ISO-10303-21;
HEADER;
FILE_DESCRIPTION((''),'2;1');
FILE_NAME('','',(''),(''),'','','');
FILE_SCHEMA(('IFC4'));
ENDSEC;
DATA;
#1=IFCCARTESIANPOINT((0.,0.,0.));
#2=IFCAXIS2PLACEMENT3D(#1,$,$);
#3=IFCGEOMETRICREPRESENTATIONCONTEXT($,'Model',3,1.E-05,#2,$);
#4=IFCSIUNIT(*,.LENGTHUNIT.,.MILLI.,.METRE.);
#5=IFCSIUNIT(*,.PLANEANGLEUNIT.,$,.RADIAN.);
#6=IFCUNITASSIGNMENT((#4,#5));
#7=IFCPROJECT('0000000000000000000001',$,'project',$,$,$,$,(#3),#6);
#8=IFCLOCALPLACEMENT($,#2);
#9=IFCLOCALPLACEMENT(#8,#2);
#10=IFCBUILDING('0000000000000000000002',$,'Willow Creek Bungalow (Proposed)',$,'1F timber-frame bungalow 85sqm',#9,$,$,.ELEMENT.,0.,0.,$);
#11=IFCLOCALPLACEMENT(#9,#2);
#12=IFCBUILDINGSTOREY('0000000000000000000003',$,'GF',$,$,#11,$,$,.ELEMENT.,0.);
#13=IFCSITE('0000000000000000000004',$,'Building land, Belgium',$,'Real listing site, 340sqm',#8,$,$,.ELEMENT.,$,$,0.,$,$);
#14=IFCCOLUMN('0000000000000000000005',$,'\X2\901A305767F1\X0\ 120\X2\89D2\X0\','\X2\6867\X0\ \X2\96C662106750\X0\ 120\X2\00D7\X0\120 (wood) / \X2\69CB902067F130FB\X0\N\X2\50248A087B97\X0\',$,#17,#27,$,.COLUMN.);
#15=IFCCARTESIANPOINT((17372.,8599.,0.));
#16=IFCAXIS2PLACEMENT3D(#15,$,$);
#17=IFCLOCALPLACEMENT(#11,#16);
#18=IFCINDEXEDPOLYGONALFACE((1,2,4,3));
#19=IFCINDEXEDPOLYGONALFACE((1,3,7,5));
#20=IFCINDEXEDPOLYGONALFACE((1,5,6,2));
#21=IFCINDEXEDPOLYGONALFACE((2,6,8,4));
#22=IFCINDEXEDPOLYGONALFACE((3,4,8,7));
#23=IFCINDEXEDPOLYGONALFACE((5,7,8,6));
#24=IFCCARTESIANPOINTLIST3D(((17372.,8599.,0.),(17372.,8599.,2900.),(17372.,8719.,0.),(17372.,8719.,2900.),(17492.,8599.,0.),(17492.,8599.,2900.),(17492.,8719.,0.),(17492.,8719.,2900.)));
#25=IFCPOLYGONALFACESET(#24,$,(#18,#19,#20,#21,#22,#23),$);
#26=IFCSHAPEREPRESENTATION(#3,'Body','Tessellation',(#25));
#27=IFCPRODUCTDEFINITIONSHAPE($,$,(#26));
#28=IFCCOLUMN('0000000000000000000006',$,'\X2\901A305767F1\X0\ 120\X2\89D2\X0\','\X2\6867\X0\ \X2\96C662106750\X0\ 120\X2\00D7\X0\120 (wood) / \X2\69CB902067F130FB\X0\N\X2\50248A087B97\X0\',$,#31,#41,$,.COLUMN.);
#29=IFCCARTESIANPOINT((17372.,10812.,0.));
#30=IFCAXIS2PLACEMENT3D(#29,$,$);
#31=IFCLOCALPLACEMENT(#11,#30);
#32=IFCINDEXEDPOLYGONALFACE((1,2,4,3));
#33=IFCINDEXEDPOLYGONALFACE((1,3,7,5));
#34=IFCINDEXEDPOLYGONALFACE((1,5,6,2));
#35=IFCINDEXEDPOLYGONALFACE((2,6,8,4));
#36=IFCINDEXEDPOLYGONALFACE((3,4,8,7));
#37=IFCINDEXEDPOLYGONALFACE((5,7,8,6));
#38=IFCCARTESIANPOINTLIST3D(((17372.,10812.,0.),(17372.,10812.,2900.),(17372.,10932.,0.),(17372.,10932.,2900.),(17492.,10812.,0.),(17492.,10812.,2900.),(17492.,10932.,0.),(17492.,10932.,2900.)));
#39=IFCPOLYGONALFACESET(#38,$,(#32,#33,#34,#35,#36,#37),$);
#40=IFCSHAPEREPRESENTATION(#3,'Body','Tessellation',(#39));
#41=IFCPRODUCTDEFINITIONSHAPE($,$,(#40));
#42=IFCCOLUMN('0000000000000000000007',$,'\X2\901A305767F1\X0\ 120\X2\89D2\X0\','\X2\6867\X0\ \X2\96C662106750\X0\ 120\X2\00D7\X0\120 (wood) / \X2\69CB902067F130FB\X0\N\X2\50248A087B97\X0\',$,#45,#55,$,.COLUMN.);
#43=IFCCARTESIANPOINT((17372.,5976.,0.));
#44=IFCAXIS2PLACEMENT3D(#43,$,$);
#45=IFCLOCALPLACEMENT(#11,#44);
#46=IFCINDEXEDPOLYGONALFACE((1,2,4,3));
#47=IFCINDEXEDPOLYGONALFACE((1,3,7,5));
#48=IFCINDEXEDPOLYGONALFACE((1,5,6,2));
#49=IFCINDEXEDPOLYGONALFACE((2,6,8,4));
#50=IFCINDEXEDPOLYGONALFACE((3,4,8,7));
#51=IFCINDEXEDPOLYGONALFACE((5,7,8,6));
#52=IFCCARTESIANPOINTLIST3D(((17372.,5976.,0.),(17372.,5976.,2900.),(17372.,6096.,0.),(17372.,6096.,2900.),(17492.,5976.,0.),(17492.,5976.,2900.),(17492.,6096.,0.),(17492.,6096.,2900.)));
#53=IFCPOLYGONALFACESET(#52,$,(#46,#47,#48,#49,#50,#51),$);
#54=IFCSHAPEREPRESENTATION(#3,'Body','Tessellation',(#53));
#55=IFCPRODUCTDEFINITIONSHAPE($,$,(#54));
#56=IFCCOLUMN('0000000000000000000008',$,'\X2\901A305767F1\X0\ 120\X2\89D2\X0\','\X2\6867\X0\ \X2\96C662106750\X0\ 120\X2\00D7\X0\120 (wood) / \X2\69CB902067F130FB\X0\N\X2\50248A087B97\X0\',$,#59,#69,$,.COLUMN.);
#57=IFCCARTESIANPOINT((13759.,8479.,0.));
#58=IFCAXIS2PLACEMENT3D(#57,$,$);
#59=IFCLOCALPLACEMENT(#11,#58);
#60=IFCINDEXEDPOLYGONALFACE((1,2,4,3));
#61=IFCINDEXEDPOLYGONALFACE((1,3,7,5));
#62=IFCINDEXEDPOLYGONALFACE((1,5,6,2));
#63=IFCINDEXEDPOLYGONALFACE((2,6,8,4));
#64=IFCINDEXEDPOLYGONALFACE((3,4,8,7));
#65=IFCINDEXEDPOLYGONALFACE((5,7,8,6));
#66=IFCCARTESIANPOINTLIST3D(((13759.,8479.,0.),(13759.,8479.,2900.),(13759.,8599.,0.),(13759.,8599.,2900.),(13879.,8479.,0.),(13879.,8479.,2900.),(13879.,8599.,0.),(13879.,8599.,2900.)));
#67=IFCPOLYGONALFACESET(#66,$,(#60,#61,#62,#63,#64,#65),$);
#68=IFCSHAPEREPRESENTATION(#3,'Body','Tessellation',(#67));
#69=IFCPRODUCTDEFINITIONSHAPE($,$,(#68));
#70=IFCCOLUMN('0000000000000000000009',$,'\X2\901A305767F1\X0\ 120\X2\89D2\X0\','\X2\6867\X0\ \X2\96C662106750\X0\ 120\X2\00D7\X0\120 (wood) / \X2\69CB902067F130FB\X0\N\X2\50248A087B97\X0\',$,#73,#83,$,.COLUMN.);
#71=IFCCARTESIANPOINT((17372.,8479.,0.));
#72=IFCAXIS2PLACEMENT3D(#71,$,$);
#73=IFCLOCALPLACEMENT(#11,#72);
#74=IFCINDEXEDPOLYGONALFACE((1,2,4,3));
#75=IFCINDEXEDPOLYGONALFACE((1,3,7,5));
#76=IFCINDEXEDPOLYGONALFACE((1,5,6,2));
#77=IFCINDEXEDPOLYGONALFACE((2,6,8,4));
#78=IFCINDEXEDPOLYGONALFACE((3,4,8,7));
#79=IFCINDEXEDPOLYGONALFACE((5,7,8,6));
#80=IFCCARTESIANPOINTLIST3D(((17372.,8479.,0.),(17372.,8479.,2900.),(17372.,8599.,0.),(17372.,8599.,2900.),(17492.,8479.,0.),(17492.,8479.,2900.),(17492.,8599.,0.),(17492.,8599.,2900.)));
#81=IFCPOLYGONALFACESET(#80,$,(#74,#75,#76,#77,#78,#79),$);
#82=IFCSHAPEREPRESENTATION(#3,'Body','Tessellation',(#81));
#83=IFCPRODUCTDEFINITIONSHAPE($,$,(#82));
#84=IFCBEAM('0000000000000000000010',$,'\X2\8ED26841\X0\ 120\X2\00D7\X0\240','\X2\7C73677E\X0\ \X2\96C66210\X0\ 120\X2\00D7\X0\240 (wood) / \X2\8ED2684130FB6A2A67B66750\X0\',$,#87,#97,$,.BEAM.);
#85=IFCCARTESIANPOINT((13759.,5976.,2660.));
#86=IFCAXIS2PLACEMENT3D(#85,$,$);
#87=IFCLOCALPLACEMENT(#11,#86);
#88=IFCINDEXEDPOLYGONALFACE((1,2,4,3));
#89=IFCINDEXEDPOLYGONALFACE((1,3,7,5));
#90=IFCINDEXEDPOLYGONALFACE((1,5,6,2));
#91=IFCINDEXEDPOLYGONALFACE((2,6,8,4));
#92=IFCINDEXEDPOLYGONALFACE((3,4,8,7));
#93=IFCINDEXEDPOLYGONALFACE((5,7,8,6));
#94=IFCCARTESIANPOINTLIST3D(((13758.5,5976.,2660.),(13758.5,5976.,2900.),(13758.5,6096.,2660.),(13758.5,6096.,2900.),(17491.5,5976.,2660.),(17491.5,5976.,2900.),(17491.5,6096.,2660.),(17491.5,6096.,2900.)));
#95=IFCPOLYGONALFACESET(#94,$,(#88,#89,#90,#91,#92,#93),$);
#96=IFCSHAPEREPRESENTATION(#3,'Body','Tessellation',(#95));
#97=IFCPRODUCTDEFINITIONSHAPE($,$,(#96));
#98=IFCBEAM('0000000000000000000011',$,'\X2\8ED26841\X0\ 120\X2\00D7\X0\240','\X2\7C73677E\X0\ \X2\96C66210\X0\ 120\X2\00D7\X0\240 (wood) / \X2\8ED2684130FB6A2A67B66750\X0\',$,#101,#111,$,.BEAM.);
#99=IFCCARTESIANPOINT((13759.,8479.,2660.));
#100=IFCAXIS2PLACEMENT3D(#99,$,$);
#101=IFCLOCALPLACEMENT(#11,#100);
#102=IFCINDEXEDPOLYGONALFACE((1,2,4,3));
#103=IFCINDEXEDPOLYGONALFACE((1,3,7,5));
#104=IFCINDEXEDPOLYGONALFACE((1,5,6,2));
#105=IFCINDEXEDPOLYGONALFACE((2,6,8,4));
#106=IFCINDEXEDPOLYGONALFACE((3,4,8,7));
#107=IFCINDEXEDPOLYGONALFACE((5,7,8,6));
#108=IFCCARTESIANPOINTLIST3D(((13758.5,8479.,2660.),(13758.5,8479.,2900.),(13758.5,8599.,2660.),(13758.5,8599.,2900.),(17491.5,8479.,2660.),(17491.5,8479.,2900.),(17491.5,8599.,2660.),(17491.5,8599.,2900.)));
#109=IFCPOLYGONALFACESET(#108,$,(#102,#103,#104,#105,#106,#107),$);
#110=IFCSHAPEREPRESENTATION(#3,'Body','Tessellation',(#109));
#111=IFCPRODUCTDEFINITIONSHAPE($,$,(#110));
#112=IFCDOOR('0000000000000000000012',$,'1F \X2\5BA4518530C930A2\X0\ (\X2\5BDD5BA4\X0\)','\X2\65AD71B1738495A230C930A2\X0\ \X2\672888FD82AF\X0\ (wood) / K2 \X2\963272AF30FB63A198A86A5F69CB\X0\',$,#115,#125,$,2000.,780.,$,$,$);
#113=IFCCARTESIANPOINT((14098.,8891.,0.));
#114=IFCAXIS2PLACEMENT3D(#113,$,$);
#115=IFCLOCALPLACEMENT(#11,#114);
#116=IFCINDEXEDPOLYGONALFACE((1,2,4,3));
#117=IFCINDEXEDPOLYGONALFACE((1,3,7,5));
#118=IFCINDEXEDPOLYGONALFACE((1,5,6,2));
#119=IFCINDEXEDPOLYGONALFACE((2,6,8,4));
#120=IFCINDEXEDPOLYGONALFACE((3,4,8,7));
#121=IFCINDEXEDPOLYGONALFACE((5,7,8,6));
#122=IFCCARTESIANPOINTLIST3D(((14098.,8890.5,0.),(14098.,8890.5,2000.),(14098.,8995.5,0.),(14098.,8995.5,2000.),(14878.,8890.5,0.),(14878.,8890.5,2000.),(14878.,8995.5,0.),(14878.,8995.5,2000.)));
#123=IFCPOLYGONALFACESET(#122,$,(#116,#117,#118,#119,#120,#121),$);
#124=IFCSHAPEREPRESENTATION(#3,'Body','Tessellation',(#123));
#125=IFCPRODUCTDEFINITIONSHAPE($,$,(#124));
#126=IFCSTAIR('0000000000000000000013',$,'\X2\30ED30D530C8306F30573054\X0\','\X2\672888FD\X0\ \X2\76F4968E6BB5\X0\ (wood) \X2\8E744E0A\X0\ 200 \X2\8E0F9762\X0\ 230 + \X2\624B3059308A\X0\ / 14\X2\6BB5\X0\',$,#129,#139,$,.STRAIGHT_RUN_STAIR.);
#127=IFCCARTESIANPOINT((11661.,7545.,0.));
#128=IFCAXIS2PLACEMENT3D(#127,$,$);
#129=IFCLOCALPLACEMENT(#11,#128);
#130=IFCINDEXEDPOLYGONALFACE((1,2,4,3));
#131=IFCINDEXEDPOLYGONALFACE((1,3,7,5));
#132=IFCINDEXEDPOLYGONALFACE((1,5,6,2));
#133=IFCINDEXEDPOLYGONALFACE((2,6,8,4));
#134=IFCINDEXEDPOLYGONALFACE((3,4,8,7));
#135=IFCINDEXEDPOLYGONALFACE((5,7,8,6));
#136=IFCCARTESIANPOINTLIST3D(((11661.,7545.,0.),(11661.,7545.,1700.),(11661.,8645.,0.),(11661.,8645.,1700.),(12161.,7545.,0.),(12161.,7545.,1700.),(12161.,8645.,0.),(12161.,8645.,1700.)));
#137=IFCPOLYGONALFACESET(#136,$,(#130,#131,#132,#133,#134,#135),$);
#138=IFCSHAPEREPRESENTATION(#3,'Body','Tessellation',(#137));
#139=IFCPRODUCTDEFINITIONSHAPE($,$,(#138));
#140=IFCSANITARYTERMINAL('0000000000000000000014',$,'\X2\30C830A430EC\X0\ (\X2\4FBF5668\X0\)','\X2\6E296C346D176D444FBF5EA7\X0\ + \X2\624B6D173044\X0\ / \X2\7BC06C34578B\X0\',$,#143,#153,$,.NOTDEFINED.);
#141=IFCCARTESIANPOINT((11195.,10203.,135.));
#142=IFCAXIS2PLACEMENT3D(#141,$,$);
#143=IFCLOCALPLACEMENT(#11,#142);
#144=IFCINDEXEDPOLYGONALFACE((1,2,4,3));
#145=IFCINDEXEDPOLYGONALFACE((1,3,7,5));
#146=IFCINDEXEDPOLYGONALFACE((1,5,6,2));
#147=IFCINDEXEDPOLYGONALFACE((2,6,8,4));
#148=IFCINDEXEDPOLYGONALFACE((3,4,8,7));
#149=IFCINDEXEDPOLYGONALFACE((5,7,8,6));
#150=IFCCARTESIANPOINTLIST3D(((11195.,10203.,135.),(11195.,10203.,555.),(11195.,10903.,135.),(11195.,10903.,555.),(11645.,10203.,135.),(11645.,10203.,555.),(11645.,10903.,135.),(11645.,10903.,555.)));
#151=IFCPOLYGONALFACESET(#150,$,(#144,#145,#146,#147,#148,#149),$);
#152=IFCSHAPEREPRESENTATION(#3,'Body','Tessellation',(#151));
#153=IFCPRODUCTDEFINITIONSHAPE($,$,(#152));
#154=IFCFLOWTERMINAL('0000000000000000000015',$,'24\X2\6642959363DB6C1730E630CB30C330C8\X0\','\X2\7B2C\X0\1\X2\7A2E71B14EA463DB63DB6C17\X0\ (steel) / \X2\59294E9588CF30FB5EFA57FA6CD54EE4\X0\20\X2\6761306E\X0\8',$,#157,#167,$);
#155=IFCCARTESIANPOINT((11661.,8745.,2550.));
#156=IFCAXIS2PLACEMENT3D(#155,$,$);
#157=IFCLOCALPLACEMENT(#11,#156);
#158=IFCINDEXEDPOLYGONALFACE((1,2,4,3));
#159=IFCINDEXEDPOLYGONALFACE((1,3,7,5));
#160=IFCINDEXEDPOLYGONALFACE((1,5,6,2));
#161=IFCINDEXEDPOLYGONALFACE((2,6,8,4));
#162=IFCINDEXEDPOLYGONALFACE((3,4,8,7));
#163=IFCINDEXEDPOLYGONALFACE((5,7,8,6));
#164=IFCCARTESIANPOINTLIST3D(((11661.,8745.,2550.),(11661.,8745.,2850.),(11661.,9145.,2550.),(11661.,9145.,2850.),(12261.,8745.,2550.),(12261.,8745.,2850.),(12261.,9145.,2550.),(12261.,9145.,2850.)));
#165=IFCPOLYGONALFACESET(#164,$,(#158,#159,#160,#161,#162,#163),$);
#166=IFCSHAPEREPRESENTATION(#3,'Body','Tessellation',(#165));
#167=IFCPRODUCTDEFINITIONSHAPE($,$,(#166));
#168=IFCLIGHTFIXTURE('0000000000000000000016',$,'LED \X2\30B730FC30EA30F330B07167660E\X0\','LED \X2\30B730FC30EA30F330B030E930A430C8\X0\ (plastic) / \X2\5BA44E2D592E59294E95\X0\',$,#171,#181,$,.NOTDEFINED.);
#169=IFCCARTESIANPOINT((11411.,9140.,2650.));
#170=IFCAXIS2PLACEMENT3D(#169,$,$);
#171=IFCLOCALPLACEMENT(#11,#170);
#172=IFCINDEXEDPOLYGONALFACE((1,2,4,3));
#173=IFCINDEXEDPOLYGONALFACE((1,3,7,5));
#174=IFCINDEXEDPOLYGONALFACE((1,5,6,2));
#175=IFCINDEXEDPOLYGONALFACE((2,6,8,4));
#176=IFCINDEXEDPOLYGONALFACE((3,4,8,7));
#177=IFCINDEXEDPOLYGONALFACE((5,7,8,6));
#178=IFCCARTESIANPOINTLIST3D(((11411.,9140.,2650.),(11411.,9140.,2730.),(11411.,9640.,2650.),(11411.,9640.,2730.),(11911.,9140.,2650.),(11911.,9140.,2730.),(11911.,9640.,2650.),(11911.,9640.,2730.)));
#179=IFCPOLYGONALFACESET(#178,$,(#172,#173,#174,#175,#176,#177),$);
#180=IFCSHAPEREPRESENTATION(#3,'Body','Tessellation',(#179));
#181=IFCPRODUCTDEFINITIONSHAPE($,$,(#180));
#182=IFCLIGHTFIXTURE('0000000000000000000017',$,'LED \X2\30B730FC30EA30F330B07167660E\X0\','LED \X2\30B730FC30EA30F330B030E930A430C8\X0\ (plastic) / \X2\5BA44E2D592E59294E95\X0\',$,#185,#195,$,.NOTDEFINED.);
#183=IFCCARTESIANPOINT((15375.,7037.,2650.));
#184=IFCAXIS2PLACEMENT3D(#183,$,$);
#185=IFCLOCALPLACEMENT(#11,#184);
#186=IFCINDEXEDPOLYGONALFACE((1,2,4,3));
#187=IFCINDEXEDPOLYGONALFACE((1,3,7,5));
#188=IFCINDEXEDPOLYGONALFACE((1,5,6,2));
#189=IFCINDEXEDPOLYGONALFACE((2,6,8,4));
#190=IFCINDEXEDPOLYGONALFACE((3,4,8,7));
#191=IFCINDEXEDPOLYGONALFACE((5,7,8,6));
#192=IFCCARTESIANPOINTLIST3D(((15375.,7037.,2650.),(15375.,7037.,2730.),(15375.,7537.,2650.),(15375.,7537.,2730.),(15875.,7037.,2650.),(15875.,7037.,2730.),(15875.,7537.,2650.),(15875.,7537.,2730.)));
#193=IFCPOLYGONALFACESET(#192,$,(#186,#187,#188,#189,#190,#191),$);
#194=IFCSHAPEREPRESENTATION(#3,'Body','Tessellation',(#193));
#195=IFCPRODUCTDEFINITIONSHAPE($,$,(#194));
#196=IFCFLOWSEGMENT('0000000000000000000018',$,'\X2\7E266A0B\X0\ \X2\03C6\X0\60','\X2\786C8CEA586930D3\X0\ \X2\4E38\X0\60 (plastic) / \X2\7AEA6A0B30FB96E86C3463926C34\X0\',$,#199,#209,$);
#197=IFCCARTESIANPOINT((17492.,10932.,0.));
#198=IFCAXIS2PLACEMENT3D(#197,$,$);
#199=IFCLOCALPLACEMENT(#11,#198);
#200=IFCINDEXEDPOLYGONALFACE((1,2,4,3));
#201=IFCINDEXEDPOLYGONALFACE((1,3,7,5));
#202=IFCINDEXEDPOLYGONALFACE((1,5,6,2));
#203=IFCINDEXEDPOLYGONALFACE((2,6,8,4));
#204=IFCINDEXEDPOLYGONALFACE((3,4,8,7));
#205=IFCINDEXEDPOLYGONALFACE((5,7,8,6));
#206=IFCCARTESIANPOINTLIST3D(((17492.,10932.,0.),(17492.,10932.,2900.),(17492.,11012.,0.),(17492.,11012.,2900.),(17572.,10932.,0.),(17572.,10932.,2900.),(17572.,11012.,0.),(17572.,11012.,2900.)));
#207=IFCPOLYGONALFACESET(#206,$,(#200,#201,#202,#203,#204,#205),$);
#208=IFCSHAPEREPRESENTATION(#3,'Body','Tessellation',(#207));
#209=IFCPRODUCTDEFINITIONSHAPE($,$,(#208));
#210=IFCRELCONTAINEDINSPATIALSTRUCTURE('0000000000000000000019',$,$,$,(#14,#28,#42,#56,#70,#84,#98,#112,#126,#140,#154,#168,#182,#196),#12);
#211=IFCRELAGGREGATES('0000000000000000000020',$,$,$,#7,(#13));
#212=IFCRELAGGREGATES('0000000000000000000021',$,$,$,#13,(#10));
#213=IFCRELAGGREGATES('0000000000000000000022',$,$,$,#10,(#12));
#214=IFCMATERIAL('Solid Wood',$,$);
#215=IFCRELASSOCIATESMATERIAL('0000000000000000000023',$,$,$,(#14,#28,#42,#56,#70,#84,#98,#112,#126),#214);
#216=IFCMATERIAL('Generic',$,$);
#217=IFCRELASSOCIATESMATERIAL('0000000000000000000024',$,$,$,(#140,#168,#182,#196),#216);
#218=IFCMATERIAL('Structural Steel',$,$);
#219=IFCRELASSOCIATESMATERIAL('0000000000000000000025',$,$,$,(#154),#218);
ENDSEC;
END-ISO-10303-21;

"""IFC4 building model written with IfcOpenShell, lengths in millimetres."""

from ifc_helpers import new_model, si_unit, frame, frame_2d, origin, place, context, project, spatial, rectangle, extrude, material, element, save


model = new_model("IFC4")

# Units and contexts
model_context = context("Model", 3, precision=1e-05, world=origin())
ifc_project = project(units=[si_unit("LENGTHUNIT", "METRE", prefix="MILLI"), si_unit("PLANEANGLEUNIT", "RADIAN")], contexts=[model_context])

# Site, building, storey
site_placement = place(None, origin())
site = spatial("IfcSite", under=ifc_project, at=site_placement, Name="Building land, Belgium", ObjectType="Real listing site, 340sqm", CompositionType="ELEMENT", RefElevation=0.0)
building_placement = place(site_placement, origin())
building = spatial("IfcBuilding", under=site, at=building_placement, Name="Willow Creek Bungalow (Proposed)", ObjectType="1F timber-frame bungalow 85sqm", CompositionType="ELEMENT", ElevationOfRefHeight=0.0, ElevationOfTerrain=0.0)
storey_placement = place(building_placement, origin())
storey = spatial("IfcBuildingStorey", under=building, at=storey_placement, Name="GF", CompositionType="ELEMENT", Elevation=0.0)

# Columns
ifc_material_1 = material(Name="Solid Wood")
column_1_placement = place(storey_placement, frame((17372.0, 8599.0, 0.0)))
element("IfcColumn", 1, at=column_1_placement, inside=storey, material=ifc_material_1, Name="通し柱 120角", Description="桧 集成材 120×120 (wood) / 構造柱・N値計算", PredefinedType="COLUMN", context=model_context, shape_type="SweptSolid", body=[
    extrude(rectangle(XDim=120.0, YDim=120.0, at=frame_2d((60.0, 60.0))), frame((17372.0, 8599.0, 0.0)), (0.0, 0.0, 1.0), 2900.0),
])
column_2_placement = place(storey_placement, frame((17372.0, 10812.0, 0.0)))
element("IfcColumn", 2, at=column_2_placement, inside=storey, material=ifc_material_1, Name="通し柱 120角", Description="桧 集成材 120×120 (wood) / 構造柱・N値計算", PredefinedType="COLUMN", context=model_context, shape_type="SweptSolid", body=[
    extrude(rectangle(XDim=120.0, YDim=120.0, at=frame_2d((60.0, 60.0))), frame((17372.0, 10812.0, 0.0)), (0.0, 0.0, 1.0), 2900.0),
])
column_3_placement = place(storey_placement, frame((17372.0, 5976.0, 0.0)))
element("IfcColumn", 3, at=column_3_placement, inside=storey, material=ifc_material_1, Name="通し柱 120角", Description="桧 集成材 120×120 (wood) / 構造柱・N値計算", PredefinedType="COLUMN", context=model_context, shape_type="SweptSolid", body=[
    extrude(rectangle(XDim=120.0, YDim=120.0, at=frame_2d((60.0, 60.0))), frame((17372.0, 5976.0, 0.0)), (0.0, 0.0, 1.0), 2900.0),
])
column_4_placement = place(storey_placement, frame((13759.0, 8479.0, 0.0)))
element("IfcColumn", 4, at=column_4_placement, inside=storey, material=ifc_material_1, Name="通し柱 120角", Description="桧 集成材 120×120 (wood) / 構造柱・N値計算", PredefinedType="COLUMN", context=model_context, shape_type="SweptSolid", body=[
    extrude(rectangle(XDim=120.0, YDim=120.0, at=frame_2d((60.0, 60.0))), frame((13759.0, 8479.0, 0.0)), (0.0, 0.0, 1.0), 2900.0),
])
column_5_placement = place(storey_placement, frame((17372.0, 8479.0, 0.0)))
element("IfcColumn", 5, at=column_5_placement, inside=storey, material=ifc_material_1, Name="通し柱 120角", Description="桧 集成材 120×120 (wood) / 構造柱・N値計算", PredefinedType="COLUMN", context=model_context, shape_type="SweptSolid", body=[
    extrude(rectangle(XDim=120.0, YDim=120.0, at=frame_2d((60.0, 60.0))), frame((17372.0, 8479.0, 0.0)), (0.0, 0.0, 1.0), 2900.0),
])

# Beams
beam_1_placement = place(storey_placement, frame((13759.0, 5976.0, 2660.0)))
element("IfcBeam", 6, at=beam_1_placement, inside=storey, material=ifc_material_1, Name="軒桁 120×240", Description="米松 集成 120×240 (wood) / 軒桁・横架材", PredefinedType="BEAM", context=model_context, shape_type="SweptSolid", body=[
    extrude(rectangle(XDim=3733.0, YDim=120.0, at=frame_2d((1866.0, 60.0))), frame((13759.0, 5976.0, 2660.0)), (0.0, 0.0, 1.0), 240.0),
])
beam_2_placement = place(storey_placement, frame((13759.0, 8479.0, 2660.0)))
element("IfcBeam", 7, at=beam_2_placement, inside=storey, material=ifc_material_1, Name="軒桁 120×240", Description="米松 集成 120×240 (wood) / 軒桁・横架材", PredefinedType="BEAM", context=model_context, shape_type="SweptSolid", body=[
    extrude(rectangle(XDim=3733.0, YDim=120.0, at=frame_2d((1866.0, 60.0))), frame((13759.0, 8479.0, 2660.0)), (0.0, 0.0, 1.0), 240.0),
])

# Door
door_placement = place(storey_placement, frame((14098.0, 8891.0, 0.0)))
element("IfcDoor", 8, at=door_placement, inside=storey, material=ifc_material_1, Name="1F 室内ドア (寝室)", Description="断熱玄関ドア 木製芯 (wood) / K2 防犯・採風機構", OverallHeight=2000.0, OverallWidth=780.0, context=model_context, shape_type="SweptSolid", body=[
    extrude(rectangle(XDim=780.0, YDim=105.0, at=frame_2d((390.0, 52.0))), frame((14098.0, 8891.0, 0.0)), (0.0, 0.0, 1.0), 2000.0),
])

# Stair
stair_placement = place(storey_placement, frame((11661.0, 7545.0, 0.0)))
element("IfcStair", 9, at=stair_placement, inside=storey, material=ifc_material_1, Name="ロフトはしご", Description="木製 直階段 (wood) 蹴上 200 踏面 230 + 手すり / 14段", PredefinedType="STRAIGHT_RUN_STAIR", context=model_context, shape_type="SweptSolid", body=[
    extrude(rectangle(XDim=500.0, YDim=1100.0, at=frame_2d((250.0, 550.0))), frame((11661.0, 7545.0, 0.0)), (0.0, 0.0, 1.0), 1700.0),
])

# Shared definitions
ifc_material_2 = material(Name="Generic")

# Sanitary terminal
sanitary_terminal_placement = place(storey_placement, frame((11195.0, 10203.0, 135.0)))
element("IfcSanitaryTerminal", 10, at=sanitary_terminal_placement, inside=storey, material=ifc_material_2, Name="トイレ (便器)", Description="温水洗浄便座 + 手洗い / 節水型", PredefinedType="NOTDEFINED", context=model_context, shape_type="SweptSolid", body=[
    extrude(rectangle(XDim=450.0, YDim=700.0, at=frame_2d((225.0, 350.0))), frame((11195.0, 10203.0, 135.0)), (0.0, 0.0, 1.0), 420.0),
])

# Flow terminal
ifc_material_3 = material(Name="Structural Steel")
flow_terminal_placement = place(storey_placement, frame((11661.0, 8745.0, 2550.0)))
element("IfcFlowTerminal", 11, at=flow_terminal_placement, inside=storey, material=ifc_material_3, Name="24時間換気ユニット", Description="第1種熱交換換気 (steel) / 天井裏・建基法令20条の8", context=model_context, shape_type="SweptSolid", body=[
    extrude(rectangle(XDim=600.0, YDim=400.0, at=frame_2d((300.0, 200.0))), frame((11661.0, 8745.0, 2550.0)), (0.0, 0.0, 1.0), 300.0),
])

# Light fixtures
light_fixture_1_placement = place(storey_placement, frame((11411.0, 9140.0, 2650.0)))
element("IfcLightFixture", 12, at=light_fixture_1_placement, inside=storey, material=ifc_material_2, Name="LED シーリング照明", Description="LED シーリングライト (plastic) / 室中央天井", PredefinedType="NOTDEFINED", context=model_context, shape_type="SweptSolid", body=[
    extrude(rectangle(XDim=500.0, YDim=500.0, at=frame_2d((250.0, 250.0))), frame((11411.0, 9140.0, 2650.0)), (0.0, 0.0, 1.0), 80.0),
])
light_fixture_2_placement = place(storey_placement, frame((15375.0, 7037.0, 2650.0)))
element("IfcLightFixture", 13, at=light_fixture_2_placement, inside=storey, material=ifc_material_2, Name="LED シーリング照明", Description="LED シーリングライト (plastic) / 室中央天井", PredefinedType="NOTDEFINED", context=model_context, shape_type="SweptSolid", body=[
    extrude(rectangle(XDim=500.0, YDim=500.0, at=frame_2d((250.0, 250.0))), frame((15375.0, 7037.0, 2650.0)), (0.0, 0.0, 1.0), 80.0),
])

# Flow segment
flow_segment_placement = place(storey_placement, frame((17492.0, 10932.0, 0.0)))
element("IfcFlowSegment", 14, at=flow_segment_placement, inside=storey, material=ifc_material_2, Name="縦樋 φ60", Description="硬質塩ビ 丸60 (plastic) / 竪樋・雨水排水", context=model_context, shape_type="SweptSolid", body=[
    extrude(rectangle(XDim=80.0, YDim=80.0, at=frame_2d((40.0, 40.0))), frame((17492.0, 10932.0, 0.0)), (0.0, 0.0, 1.0), 2900.0),
])

save(model, "model.ifc")
